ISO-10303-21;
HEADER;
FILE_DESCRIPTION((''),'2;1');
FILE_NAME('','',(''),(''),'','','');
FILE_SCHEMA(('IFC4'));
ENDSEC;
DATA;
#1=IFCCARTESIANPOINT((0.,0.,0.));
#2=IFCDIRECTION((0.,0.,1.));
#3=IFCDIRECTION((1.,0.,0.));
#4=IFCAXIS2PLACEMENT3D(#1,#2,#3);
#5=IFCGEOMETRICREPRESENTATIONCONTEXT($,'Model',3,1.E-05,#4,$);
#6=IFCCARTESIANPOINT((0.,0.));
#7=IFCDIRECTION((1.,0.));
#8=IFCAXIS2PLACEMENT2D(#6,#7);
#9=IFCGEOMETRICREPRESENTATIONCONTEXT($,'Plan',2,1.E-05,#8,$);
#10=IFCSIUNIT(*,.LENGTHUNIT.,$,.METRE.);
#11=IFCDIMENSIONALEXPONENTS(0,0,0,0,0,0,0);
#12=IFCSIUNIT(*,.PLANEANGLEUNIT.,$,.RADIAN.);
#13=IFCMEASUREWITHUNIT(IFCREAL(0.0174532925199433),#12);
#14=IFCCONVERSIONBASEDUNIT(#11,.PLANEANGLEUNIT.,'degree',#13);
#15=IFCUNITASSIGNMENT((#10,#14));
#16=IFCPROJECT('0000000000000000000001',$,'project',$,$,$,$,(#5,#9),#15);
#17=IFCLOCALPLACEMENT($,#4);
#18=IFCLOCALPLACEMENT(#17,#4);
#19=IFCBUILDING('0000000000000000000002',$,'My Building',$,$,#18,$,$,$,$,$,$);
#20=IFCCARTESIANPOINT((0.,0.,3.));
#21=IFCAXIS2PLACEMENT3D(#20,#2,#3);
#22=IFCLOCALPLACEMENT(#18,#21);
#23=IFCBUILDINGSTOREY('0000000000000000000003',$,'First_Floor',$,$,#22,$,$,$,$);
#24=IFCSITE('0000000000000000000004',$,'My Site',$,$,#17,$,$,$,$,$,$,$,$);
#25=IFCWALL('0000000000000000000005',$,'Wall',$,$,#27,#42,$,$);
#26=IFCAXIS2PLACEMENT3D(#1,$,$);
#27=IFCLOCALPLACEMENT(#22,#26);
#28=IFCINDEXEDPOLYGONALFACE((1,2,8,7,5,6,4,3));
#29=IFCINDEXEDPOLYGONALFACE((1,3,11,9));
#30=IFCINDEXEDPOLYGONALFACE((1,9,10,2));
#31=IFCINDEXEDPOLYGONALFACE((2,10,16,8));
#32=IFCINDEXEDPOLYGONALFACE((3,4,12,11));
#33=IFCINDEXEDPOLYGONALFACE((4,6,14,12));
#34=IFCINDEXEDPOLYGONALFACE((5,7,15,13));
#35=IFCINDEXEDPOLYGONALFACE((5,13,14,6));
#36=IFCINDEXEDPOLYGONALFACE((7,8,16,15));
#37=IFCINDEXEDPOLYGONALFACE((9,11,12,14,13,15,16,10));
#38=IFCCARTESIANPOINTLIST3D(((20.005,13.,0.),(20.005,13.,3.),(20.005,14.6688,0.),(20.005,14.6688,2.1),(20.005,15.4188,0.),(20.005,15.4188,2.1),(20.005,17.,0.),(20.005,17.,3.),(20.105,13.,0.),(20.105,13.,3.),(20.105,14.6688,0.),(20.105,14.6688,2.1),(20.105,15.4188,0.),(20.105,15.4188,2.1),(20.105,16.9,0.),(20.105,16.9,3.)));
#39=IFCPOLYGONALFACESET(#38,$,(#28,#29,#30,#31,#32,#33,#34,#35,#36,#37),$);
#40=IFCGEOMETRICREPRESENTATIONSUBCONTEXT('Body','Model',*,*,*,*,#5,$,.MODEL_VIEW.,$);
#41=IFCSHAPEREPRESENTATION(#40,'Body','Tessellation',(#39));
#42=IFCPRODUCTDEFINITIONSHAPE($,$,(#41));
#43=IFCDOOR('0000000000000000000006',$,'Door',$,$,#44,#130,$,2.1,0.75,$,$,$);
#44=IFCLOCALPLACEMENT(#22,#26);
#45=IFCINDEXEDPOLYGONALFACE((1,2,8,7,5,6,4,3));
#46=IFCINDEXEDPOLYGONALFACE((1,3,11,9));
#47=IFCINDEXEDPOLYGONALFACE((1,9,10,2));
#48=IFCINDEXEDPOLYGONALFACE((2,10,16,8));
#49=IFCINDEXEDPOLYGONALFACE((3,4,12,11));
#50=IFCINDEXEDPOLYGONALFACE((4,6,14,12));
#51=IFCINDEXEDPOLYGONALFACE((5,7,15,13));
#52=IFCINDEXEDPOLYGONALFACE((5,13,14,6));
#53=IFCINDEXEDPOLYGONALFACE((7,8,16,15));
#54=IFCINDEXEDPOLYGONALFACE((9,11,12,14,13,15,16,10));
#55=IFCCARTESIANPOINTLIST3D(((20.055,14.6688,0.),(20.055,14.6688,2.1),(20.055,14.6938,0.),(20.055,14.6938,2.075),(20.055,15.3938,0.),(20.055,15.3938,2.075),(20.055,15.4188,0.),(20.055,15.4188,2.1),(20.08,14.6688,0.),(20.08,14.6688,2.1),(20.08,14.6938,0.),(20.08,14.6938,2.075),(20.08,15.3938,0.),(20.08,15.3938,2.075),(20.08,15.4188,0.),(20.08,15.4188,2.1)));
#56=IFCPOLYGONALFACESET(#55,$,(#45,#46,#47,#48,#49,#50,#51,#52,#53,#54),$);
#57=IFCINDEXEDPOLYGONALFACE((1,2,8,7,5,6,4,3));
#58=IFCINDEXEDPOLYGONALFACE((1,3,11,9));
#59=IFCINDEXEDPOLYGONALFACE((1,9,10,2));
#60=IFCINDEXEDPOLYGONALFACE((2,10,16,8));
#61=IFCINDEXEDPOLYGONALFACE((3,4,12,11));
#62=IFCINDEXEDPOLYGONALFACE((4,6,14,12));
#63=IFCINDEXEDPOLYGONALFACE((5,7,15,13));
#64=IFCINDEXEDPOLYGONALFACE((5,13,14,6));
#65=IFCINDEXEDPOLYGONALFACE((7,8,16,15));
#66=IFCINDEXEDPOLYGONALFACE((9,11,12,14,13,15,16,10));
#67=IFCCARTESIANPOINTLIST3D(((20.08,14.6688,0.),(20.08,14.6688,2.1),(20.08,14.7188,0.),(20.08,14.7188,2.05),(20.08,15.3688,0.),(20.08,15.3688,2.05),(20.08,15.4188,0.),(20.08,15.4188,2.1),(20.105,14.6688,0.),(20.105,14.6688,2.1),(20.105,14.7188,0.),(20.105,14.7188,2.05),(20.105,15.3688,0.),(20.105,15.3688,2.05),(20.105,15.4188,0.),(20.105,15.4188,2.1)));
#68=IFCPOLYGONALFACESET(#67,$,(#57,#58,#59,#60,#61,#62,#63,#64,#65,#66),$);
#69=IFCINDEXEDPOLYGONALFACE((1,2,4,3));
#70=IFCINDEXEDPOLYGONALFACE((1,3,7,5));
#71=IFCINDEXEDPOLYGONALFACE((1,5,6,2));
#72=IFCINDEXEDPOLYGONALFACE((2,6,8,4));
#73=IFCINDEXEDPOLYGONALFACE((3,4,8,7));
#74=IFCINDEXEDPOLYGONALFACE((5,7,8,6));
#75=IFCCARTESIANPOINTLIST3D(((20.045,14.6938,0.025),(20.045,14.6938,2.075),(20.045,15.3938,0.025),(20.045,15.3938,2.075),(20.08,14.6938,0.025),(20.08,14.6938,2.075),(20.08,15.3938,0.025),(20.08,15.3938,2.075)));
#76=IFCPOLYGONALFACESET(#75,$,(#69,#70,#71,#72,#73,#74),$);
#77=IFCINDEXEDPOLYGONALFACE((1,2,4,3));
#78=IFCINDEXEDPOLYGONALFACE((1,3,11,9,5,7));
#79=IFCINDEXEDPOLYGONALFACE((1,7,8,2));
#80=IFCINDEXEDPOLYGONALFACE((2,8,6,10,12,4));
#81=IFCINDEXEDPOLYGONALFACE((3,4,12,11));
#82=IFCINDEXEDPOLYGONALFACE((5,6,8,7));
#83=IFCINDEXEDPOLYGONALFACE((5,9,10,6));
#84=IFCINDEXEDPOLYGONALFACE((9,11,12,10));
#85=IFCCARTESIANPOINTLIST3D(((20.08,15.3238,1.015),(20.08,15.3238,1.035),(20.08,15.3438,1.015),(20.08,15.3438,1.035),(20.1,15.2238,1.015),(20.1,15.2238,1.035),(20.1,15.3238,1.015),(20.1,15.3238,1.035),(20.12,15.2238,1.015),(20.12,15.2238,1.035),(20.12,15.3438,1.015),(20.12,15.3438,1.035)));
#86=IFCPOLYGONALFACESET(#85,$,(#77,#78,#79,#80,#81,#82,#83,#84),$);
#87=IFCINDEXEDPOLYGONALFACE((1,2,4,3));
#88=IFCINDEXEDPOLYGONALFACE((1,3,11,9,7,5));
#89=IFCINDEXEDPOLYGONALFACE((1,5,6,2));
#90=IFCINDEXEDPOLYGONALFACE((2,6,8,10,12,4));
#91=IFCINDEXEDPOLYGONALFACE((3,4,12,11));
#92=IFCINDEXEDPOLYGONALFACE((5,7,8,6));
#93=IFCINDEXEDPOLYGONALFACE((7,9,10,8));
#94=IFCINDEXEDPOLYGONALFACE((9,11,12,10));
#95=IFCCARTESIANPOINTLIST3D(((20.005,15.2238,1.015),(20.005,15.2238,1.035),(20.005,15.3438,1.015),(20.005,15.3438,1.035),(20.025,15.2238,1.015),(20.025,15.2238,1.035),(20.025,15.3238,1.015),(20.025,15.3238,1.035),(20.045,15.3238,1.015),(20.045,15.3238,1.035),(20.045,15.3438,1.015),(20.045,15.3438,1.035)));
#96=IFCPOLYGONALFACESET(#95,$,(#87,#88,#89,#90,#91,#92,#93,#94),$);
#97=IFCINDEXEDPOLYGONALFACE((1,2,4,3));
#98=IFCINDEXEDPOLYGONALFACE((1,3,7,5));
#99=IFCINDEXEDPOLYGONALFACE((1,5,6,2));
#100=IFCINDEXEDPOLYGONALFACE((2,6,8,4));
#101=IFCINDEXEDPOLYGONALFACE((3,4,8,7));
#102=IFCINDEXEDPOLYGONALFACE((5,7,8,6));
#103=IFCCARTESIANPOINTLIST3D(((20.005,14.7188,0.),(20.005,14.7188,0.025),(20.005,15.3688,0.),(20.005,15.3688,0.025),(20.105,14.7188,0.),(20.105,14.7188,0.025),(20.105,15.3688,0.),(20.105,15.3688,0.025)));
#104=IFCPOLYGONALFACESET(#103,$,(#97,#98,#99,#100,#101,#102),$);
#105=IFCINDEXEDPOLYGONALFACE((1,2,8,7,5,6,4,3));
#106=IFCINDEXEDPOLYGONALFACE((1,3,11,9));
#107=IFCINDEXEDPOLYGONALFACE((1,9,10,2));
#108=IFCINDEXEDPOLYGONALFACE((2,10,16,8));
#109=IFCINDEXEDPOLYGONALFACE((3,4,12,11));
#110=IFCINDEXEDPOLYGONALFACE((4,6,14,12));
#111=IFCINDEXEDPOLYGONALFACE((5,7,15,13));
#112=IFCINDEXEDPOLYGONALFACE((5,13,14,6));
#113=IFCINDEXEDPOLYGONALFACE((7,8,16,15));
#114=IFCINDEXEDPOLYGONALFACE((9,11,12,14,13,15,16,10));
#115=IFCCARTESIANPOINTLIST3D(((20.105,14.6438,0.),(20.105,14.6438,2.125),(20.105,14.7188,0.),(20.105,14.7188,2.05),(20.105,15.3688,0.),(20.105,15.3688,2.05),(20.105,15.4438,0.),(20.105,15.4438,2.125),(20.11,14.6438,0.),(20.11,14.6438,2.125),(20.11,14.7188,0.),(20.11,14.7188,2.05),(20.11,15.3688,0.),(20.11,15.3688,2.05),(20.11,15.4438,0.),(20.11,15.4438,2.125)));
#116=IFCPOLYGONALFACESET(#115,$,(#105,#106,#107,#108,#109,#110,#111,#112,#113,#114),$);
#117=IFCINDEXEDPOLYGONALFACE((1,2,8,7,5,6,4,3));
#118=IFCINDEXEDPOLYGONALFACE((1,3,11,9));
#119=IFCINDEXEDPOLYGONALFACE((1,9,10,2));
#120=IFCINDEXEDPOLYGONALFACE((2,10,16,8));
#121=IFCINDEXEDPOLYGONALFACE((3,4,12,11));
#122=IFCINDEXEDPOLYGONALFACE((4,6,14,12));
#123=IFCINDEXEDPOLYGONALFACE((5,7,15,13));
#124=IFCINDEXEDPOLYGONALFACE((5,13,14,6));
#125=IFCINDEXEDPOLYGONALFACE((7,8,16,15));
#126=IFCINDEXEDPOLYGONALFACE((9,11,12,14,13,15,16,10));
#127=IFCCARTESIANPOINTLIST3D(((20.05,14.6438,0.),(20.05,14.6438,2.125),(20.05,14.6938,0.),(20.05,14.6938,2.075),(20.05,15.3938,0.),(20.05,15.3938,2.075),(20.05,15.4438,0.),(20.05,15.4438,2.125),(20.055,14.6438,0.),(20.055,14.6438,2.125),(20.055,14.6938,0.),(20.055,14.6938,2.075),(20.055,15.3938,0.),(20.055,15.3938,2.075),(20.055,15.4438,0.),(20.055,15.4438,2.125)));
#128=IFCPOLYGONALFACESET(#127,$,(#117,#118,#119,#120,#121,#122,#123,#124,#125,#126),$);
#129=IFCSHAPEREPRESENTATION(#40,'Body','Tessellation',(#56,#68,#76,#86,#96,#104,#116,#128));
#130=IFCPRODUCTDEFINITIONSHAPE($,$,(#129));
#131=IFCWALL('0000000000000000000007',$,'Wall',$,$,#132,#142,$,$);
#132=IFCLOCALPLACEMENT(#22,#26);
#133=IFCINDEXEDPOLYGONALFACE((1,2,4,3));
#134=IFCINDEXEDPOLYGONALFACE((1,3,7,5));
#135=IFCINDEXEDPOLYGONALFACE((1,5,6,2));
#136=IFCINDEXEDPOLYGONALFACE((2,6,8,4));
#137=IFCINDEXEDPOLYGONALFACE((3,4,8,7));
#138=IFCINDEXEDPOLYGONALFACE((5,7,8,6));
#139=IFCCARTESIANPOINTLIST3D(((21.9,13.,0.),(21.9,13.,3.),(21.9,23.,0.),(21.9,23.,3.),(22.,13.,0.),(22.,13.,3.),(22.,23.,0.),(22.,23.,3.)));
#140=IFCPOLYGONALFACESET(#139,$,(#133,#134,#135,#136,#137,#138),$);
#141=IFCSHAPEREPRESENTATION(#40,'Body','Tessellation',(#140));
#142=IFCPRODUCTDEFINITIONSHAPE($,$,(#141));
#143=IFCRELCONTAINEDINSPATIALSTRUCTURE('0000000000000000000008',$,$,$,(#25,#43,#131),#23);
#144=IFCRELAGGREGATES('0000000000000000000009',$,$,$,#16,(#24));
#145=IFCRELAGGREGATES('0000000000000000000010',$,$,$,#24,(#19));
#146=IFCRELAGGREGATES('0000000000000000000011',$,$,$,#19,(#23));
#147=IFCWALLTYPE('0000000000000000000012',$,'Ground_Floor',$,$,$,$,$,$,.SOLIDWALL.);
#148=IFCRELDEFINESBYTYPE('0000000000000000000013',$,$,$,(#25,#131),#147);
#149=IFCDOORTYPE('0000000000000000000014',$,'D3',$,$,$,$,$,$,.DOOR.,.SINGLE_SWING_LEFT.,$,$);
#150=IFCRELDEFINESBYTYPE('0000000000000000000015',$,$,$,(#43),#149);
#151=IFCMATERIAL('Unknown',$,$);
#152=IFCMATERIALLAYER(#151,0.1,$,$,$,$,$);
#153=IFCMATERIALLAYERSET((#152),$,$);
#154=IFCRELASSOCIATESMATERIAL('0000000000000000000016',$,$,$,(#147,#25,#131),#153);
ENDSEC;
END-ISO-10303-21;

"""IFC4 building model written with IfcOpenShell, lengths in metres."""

from ifc_helpers import new_model, entity, si_unit, converted_unit, frame, origin_with_axes, origin_2d_with_axis, place, context, subcontext, project, spatial, line, indexed_curve, outline, extrude, shape, source, transform, mapped, material, layer, layer_set, layer_usage, type_object, type_shapes, element, fill, save


model = new_model("IFC4")

# Units and contexts
model_context = context("Model", 3, precision=1e-05, world=origin_with_axes())
plan_context = context("Plan", 2, precision=1e-05, world=origin_2d_with_axis())
body_context_1 = subcontext(model_context, "Body", "Model", "MODEL_VIEW")
body_context_2 = subcontext(plan_context, "Body", "Plan", "PLAN_VIEW")
ifc_project = project(units=[si_unit("LENGTHUNIT", "METRE"), converted_unit("PLANEANGLEUNIT", "degree", entity("IfcReal", 0.0174532925199433), si_unit("PLANEANGLEUNIT", "RADIAN"), dimensions=[0, 0, 0, 0, 0, 0, 0])], contexts=[model_context, plan_context])

# Site, building, storey
site_placement = place(None, origin_with_axes())
site = spatial("IfcSite", under=ifc_project, at=site_placement, Name="My Site")
building_placement = place(site_placement, origin_with_axes())
building = spatial("IfcBuilding", under=site, at=building_placement, Name="My Building")
storey_placement = place(building_placement, frame((0.0, 0.0, 3.0), z_axis=(0.0, 0.0, 1.0), x_axis=(1.0, 0.0, 0.0)))
storey = spatial("IfcBuildingStorey", under=building, at=storey_placement, Name="First_Floor")

# Shared definitions
ifc_material = material(Name="Unknown")

# Shared definitions
ifc_layer = layer(ifc_material, 0.1)
ifc_layer_set = layer_set([ifc_layer])
wall_type = type_object("IfcWallType", Name="Ground_Floor", PredefinedType="SOLIDWALL", material=ifc_layer_set)

# Wall, opening, door
shared_shape_1 = source(origin_with_axes(), body_context_1, "Body", "SweptSolid", [
    extrude(outline(indexed_curve([(0.0, 0.0), (0.75, 0.0), (0.75, 2.1), (0.0, 2.1)], segments=[line(1, 2, 3, 4, 1)])), frame((0.0, -0.6, 0.0), z_axis=(0.0, -1.0, 0.0), x_axis=(1.0, 0.0, 0.0)), (0.0, 0.0, -1.0), 1.2),
])
door_type_1 = type_object("IfcDoorType", Name="D3", OperationType="SINGLE_SWING_LEFT", PredefinedType="DOOR")
shared_shape_2 = source(origin_with_axes(), body_context_1, "Body", "SweptSolid", [
    extrude(outline(indexed_curve([(0.0, 0.0), (0.0, 2.1), (0.75, 2.1), (0.75, 0.0), (0.725, 0.0), (0.725, 2.075), (0.025, 2.075), (0.025, 0.0)], segments=[line(1, 2, 3, 4, 5, 6, 7, 8, 1)])), frame((0.0, 0.025, 0.0), z_axis=(0.0, -1.0, 0.0), x_axis=(1.0, 0.0, 0.0)), (0.0, 0.0, -1.0), 0.025),
    extrude(outline(indexed_curve([(0.0, 0.0), (0.0, 2.1), (0.75, 2.1), (0.75, 0.0), (0.7, 0.0), (0.7, 2.05), (0.05, 2.05), (0.05, 0.0)], segments=[line(1, 2, 3, 4, 5, 6, 7, 8, 1)])), frame((0.0, 0.0, 0.0), z_axis=(0.0, -1.0, 0.0), x_axis=(1.0, 0.0, 0.0)), (0.0, 0.0, -1.0), 0.025),
    extrude(outline(indexed_curve([(0.0, 0.0), (0.7, 0.0), (0.7, 0.035), (0.0, 0.035)], segments=[line(1, 2, 3, 4, 1)])), frame((0.025, 0.025, 0.025), z_axis=(0.0, 0.0, 1.0), x_axis=(1.0, 0.0, 0.0)), (0.0, 0.0, 1.0), 2.05),
    extrude(outline(indexed_curve([(0.0, 0.0), (0.0, -0.04), (-0.12, -0.04), (-0.12, -0.02), (-0.02, -0.02), (-0.02, 0.0)], segments=[line(1, 2, 3, 4, 5, 6, 1)])), frame((0.675, 0.025, 1.015), z_axis=(0.0, 0.0, 1.0), x_axis=(1.0, 0.0, 0.0)), (0.0, 0.0, 1.0), 0.02),
    extrude(outline(indexed_curve([(0.0, 0.0), (0.0, 0.04), (-0.12, 0.04), (-0.12, 0.02), (-0.02, 0.02), (-0.02, 0.0)], segments=[line(1, 2, 3, 4, 5, 6, 1)])), frame((0.675, 0.06, 1.015), z_axis=(0.0, 0.0, 1.0), x_axis=(1.0, 0.0, 0.0)), (0.0, 0.0, 1.0), 0.02),
    extrude(outline(indexed_curve([(0.0, 0.0), (0.65, 0.0), (0.65, 0.1), (0.0, 0.1)], segments=[line(1, 2, 3, 4, 1)])), frame((0.05, 0.0, 0.0), z_axis=(0.0, 0.0, 1.0), x_axis=(1.0, 0.0, 0.0)), (0.0, 0.0, 1.0), 0.025),
    extrude(outline(indexed_curve([(0.0, 0.0), (0.0, 2.125), (0.8, 2.125), (0.8, 0.0), (0.725, 0.0), (0.725, 2.05), (0.075, 2.05), (0.075, 0.0)], segments=[line(1, 2, 3, 4, 5, 6, 7, 8, 1)])), frame((-0.025, -0.005, 0.0), z_axis=(0.0, -1.0, 0.0), x_axis=(1.0, 0.0, 0.0)), (0.0, 0.0, -1.0), 0.005),
    extrude(outline(indexed_curve([(0.0, 0.0), (0.0, 2.125), (0.8, 2.125), (0.8, 0.0), (0.75, 0.0), (0.75, 2.075), (0.05, 2.075), (0.05, 0.0)], segments=[line(1, 2, 3, 4, 5, 6, 7, 8, 1)])), frame((-0.025, 0.05, 0.0), z_axis=(0.0, -1.0, 0.0), x_axis=(1.0, 0.0, 0.0)), (0.0, 0.0, -1.0), 0.005),
])
shared_shape_3 = source(origin_with_axes(), body_context_2, "Body", "Curve2D", [
    entity("IfcIndexedPolyCurve", entity("IfcCartesianPointList2D", [[0.0, 0.0], [0.0, 0.05], [0.025, 0.05], [0.025, 0.025], [0.05, 0.025], [0.05, 0.0]]), [entity("IfcLineIndex", [1, 2, 3, 4, 5, 6, 1])]),
    entity("IfcIndexedPolyCurve", entity("IfcCartesianPointList2D", [[0.75, 0.0], [0.75, 0.05], [0.725, 0.05], [0.725, 0.025], [0.7, 0.025], [0.7, 0.0]]), [entity("IfcLineIndex", [1, 2, 3, 4, 5, 6, 1])]),
    entity("IfcTrimmedCurve", entity("IfcEllipse", entity("IfcAxis2Placement2D", entity("IfcCartesianPoint", [0.06, 0.05]), entity("IfcDirection", [1.0, 0.0])), 0.665, 0.7), [entity("IfcCartesianPoint", [0.725, 0.05])], [entity("IfcCartesianPoint", [0.06, 0.75])], True, "CARTESIAN"),
    entity("IfcIndexedPolyCurve", entity("IfcCartesianPointList2D", [[0.025, 0.05], [0.06, 0.05], [0.06, 0.75], [0.025, 0.75]]), [entity("IfcLineIndex", [1, 2, 3, 4, 1])]),
])
type_shapes(door_type_1, [shared_shape_2, shared_shape_3])
ifc_layer_usage_1 = layer_usage(ifc_layer_set, "AXIS2", "POSITIVE", 0.0)
wall_1_placement = place(storey_placement, frame((20.005, 17.0, 0.0), z_axis=(0.0, 0.0, 1.0), x_axis=(0.0, -1.0, 0.0)))
wall_1 = element("IfcWall", 1, at=wall_1_placement, inside=storey, type_object=wall_type, material=ifc_layer_usage_1, Name="Wall", context=body_context_1, shape_type="SweptSolid", body=[
    extrude(outline(indexed_curve([(0.0, 0.0), (0.1, 0.1), (4.0, 0.1), (4.0, 0.0)], segments=[line(1, 2, 3, 4, 1)])), origin_with_axes(), (0.0, 0.0, 1.0), 3.0),
])
opening_1_placement = place(wall_1_placement, frame((2.3312, 0.1, 0.0), z_axis=(0.0, 0.0, 1.0), x_axis=(-1.0, 0.0, 0.0)))
opening_1 = element("IfcOpeningElement", 2, at=opening_1_placement, cuts=wall_1, PredefinedType="OPENING", context=body_context_1, shape_type="MappedRepresentation", body=[
    mapped(shared_shape_1, transform((0.0, 0.0, 0.0), x_axis=(1.0, 0.0, 0.0), y_axis=(0.0, 1.0, 0.0), z_axis=(0.0, 0.0, 1.0), scale=1.0)),
])
door_1_placement = place(opening_1_placement, frame((0.0, 0.0, 0.0), z_axis=(0.0, 0.0, 1.0), x_axis=(1.0, 0.0, 0.0)))
door_1 = element("IfcDoor", 3, at=door_1_placement, inside=storey, type_object=door_type_1, Name="Door", OverallHeight=2.1, OverallWidth=0.75, shapes=[
    shape(body_context_1, "Body", "MappedRepresentation", [mapped(shared_shape_2, transform((0.0, 0.0, 0.0), x_axis=(1.0, 0.0, 0.0), y_axis=(0.0, 1.0, 0.0), z_axis=(0.0, 0.0, 1.0), scale=1.0))]),
    shape(body_context_2, "Body", "MappedRepresentation", [mapped(shared_shape_3, transform((0.0, 0.0, 0.0), x_axis=(1.0, 0.0, 0.0), y_axis=(0.0, 1.0, 0.0), z_axis=(0.0, 0.0, 1.0), scale=1.0))]),
])
fill(opening_1, door_1)

# Wall
ifc_layer_usage_2 = layer_usage(ifc_layer_set, "AXIS2", "POSITIVE", 0.0)
wall_2_placement = place(storey_placement, frame((21.9, 23.0, 0.0), z_axis=(0.0, 0.0, 1.0), x_axis=(0.0, -1.0, 0.0)))
element("IfcWall", 4, at=wall_2_placement, inside=storey, type_object=wall_type, material=ifc_layer_usage_2, Name="Wall", context=body_context_1, shape_type="SweptSolid", body=[
    extrude(outline(indexed_curve([(0.0, 0.0), (0.0, 0.1), (10.0, 0.1), (10.0, 0.0)], segments=[line(1, 2, 3, 4, 1)])), origin_with_axes(), (0.0, 0.0, 1.0), 3.0),
])

save(model, "model.ifc")
